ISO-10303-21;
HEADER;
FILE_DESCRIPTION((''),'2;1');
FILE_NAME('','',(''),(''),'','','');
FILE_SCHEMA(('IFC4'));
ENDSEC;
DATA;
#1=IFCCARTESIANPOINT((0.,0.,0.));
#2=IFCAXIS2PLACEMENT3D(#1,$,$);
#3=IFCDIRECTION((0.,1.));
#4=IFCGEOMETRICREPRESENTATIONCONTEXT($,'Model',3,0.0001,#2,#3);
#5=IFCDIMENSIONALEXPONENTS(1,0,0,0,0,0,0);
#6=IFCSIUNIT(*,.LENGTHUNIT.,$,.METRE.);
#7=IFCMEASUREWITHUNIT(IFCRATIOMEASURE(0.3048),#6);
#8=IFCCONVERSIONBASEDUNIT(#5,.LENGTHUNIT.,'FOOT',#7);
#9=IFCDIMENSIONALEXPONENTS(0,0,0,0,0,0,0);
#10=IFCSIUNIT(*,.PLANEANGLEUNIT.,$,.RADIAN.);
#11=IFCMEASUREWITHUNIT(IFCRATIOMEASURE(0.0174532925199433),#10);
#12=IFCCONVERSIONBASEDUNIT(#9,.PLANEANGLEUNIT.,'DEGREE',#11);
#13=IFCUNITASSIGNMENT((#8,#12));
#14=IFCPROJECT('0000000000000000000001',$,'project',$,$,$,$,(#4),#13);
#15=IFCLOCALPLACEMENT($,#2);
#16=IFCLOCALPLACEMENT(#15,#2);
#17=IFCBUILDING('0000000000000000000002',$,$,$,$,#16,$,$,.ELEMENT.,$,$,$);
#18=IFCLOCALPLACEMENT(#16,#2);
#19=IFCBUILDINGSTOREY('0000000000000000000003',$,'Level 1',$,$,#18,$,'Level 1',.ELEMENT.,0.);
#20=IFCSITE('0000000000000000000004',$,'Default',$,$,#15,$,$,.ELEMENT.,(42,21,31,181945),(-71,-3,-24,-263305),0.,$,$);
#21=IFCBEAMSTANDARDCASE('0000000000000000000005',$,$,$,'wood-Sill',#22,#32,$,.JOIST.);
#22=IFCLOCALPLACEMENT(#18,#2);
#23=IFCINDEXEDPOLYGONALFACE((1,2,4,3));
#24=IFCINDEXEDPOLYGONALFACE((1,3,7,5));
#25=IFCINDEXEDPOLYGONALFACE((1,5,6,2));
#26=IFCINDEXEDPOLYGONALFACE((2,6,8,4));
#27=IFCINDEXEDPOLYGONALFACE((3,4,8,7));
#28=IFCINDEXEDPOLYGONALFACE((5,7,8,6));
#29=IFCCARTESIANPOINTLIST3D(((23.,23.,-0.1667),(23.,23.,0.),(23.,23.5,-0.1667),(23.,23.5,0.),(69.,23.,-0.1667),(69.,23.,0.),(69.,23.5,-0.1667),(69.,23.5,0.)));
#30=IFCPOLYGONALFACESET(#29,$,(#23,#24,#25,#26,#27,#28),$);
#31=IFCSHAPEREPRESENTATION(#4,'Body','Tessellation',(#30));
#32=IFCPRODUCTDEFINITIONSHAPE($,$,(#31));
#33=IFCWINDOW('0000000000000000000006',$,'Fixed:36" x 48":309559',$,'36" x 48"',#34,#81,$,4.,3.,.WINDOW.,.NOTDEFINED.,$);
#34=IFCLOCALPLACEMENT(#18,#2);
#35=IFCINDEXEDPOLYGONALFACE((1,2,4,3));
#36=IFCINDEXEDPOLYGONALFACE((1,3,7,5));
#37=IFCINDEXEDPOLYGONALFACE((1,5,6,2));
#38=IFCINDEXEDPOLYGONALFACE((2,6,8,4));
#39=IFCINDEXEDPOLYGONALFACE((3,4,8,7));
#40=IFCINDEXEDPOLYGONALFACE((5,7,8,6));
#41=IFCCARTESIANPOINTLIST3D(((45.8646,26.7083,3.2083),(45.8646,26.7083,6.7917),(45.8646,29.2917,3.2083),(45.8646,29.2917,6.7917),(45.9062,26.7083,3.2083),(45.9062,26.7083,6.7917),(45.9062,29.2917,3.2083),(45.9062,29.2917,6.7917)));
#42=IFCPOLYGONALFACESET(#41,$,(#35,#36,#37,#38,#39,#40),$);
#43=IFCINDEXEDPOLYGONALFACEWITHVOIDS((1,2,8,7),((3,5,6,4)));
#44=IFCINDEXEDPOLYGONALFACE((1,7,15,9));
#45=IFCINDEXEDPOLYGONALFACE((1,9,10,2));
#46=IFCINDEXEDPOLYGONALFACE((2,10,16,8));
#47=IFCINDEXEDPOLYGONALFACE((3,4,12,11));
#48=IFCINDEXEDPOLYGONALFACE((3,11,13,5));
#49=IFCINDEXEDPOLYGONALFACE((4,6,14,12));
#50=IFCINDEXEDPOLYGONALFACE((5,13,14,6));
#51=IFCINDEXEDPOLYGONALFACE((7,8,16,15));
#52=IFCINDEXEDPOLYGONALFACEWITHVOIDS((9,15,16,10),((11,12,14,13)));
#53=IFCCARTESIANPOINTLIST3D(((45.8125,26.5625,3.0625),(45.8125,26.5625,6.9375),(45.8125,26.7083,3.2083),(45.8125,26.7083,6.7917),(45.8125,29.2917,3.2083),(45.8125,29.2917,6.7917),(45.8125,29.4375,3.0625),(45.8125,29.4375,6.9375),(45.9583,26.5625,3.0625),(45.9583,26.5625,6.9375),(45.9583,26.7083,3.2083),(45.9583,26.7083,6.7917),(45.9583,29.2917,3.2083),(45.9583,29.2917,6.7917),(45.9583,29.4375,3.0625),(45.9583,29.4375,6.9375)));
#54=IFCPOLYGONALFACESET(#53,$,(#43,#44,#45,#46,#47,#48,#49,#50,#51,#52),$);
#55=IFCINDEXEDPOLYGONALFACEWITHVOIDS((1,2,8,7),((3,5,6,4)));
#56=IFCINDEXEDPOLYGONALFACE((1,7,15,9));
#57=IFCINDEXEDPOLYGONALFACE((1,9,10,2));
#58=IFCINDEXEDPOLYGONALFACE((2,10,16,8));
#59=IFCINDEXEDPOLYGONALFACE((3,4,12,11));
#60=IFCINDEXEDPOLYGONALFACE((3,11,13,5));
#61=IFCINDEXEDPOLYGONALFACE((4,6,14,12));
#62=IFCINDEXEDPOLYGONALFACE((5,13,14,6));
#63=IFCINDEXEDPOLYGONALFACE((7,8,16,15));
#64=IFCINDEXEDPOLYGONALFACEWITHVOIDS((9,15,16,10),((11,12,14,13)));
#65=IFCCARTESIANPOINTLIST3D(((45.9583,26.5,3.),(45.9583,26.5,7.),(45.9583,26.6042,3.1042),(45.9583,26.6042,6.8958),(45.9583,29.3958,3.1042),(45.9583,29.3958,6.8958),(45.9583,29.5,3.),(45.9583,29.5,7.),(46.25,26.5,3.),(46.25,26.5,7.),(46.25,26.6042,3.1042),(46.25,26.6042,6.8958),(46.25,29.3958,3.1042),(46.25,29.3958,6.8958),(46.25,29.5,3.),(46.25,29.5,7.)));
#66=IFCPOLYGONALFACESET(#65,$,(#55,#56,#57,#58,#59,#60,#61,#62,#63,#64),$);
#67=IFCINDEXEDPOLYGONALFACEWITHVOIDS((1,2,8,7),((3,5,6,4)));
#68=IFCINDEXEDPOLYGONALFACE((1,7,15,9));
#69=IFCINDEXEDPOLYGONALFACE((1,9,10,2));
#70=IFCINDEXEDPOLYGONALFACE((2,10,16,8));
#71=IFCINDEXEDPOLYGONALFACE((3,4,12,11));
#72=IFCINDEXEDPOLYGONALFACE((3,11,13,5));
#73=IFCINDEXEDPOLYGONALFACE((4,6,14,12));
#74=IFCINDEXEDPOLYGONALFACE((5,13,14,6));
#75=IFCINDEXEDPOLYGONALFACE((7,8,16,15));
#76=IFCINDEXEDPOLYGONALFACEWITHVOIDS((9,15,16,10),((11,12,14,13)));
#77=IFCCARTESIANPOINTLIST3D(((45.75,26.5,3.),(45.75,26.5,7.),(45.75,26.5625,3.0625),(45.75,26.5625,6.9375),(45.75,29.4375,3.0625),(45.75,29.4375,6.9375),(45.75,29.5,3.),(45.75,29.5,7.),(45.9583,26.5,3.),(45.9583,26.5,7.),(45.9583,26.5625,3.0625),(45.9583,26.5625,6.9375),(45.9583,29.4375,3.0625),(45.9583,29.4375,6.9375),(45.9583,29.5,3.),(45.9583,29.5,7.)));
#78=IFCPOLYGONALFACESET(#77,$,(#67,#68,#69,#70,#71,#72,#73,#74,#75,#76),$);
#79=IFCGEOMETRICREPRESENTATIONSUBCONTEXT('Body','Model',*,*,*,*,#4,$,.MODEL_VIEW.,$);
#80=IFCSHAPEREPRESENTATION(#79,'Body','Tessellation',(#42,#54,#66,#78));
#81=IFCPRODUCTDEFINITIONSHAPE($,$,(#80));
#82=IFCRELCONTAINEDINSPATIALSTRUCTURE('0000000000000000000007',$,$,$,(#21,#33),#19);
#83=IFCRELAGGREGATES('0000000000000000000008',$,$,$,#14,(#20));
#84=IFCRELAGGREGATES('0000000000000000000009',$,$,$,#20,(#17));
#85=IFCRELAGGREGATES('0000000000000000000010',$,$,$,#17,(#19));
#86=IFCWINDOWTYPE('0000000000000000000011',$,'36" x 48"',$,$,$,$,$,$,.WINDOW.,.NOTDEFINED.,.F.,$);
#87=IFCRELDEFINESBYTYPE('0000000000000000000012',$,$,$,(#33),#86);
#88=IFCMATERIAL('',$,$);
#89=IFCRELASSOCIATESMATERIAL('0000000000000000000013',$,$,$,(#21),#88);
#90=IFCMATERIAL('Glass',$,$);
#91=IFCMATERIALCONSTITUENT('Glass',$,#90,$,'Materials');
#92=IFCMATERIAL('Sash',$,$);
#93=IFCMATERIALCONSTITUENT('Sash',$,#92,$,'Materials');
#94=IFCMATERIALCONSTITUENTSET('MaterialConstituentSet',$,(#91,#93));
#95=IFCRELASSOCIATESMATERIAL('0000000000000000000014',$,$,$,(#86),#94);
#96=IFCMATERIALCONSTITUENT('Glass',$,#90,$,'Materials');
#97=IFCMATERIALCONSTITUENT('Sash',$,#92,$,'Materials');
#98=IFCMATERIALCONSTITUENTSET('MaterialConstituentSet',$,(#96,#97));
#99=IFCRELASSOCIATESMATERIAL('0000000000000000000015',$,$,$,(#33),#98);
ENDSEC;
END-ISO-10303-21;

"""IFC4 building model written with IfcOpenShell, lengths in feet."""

from ifc_helpers import new_model, entity, si_unit, converted_unit, direction, frame, frame_2d, origin, place, context, subcontext, project, spatial, polyline, rectangle, outline, extrude, source, transform, mapped, material, constituent, constituent_set, type_object, type_shapes, element, save


model = new_model("IFC4")

# Units and contexts
model_context = context("Model", 3, precision=0.0001, world=origin(), true_north=direction((0.0, 1.0)))
body_context = subcontext(model_context, "Body", "Model", "MODEL_VIEW")
ifc_project = project(units=[converted_unit("LENGTHUNIT", "FOOT", entity("IfcRatioMeasure", 0.3048), si_unit("LENGTHUNIT", "METRE"), dimensions=[1, 0, 0, 0, 0, 0, 0]), converted_unit("PLANEANGLEUNIT", "DEGREE", entity("IfcRatioMeasure", 0.0174532925199433), si_unit("PLANEANGLEUNIT", "RADIAN"), dimensions=[0, 0, 0, 0, 0, 0, 0])], contexts=[model_context])

# Site, building, storey
site_placement = place(None, origin())
site = spatial("IfcSite", under=ifc_project, at=site_placement, Name="Default", CompositionType="ELEMENT", RefLatitude=(42, 21, 31, 181945), RefLongitude=(-71, -3, -24, -263305), RefElevation=0.0)
building_placement = place(site_placement, origin())
building = spatial("IfcBuilding", under=site, at=building_placement, CompositionType="ELEMENT")
storey_placement = place(building_placement, origin())
storey = spatial("IfcBuildingStorey", under=building, at=storey_placement, Name="Level 1", LongName="Level 1", CompositionType="ELEMENT", Elevation=0.0)

# Shared definitions
placement_1 = place(storey_placement, frame((46.0, 46.25, 0.0), z_axis=(0.0, 0.0, 1.0), x_axis=(0.0, -1.0, 0.0)))

# Beam
ifc_material_1 = material(Name="")
beam_1_placement = place(placement_1, frame((23.0, 0.0, -0.1667), z_axis=(0.0, 0.0, 1.0), x_axis=(0.0, -1.0, 0.0)))
element("IfcBeamStandardCase", 1, at=beam_1_placement, inside=storey, material=ifc_material_1, ObjectType="wood-Sill", PredefinedType="JOIST", context=model_context, shape_type="SweptSolid", body=[
    extrude(rectangle(XDim=46.0, YDim=0.5), origin(), (0.0, 0.0, 1.0), 0.1667),
])

# Window
ifc_material_2 = material(Name="Glass")
ifc_constituent_1 = constituent(ifc_material_2, Name="Glass", Category="Materials")
ifc_material_3 = material(Name="Sash")
ifc_constituent_2 = constituent(ifc_material_3, Name="Sash", Category="Materials")
ifc_constituent_set_1 = constituent_set(constituents=[ifc_constituent_1, ifc_constituent_2], Name="MaterialConstituentSet")
ifc_constituent_3 = constituent(ifc_material_2, Name="Glass", Category="Materials")
ifc_constituent_4 = constituent(ifc_material_3, Name="Sash", Category="Materials")
ifc_constituent_set_2 = constituent_set(constituents=[ifc_constituent_3, ifc_constituent_4], Name="MaterialConstituentSet")
window_type = type_object("IfcWindowType", Name="36\" x 48\"", ParameterTakesPrecedence=False, PartitioningType="NOTDEFINED", PredefinedType="WINDOW", material=ifc_constituent_set_2)
shared_shape = source(origin(), body_context, "Body", "SweptSolid", [
    extrude(rectangle(XDim=0.0417, YDim=2.5833, at=frame_2d((0.0, 0.0), x_axis=(1.0, 0.0))), frame((1.5, 0.3646, 0.2083), z_axis=(0.0, 0.0, 1.0), x_axis=(0.0, 1.0, 0.0)), (0.0, 0.0, 1.0), 3.5833),
    extrude(outline(polyline([(-1.4375, -1.9375), (1.4375, -1.9375), (1.4375, 1.9375), (-1.4375, 1.9375), (-1.4375, -1.9375)]), holes=[polyline([(-1.2917, -1.7917), (-1.2917, 1.7917), (1.2917, 1.7917), (1.2917, -1.7917), (-1.2917, -1.7917)])]), frame((1.5, 0.2917, 2.0), z_axis=(0.0, 1.0, 0.0), x_axis=(1.0, 0.0, 0.0)), (0.0, 0.0, 1.0), 0.1458),
    extrude(outline(polyline([(-1.5, -2.0), (1.5, -2.0), (1.5, 2.0), (-1.5, 2.0), (-1.5, -2.0)]), holes=[polyline([(-1.3958, -1.8958), (-1.3958, 1.8958), (1.3958, 1.8958), (1.3958, -1.8958), (-1.3958, -1.8958)])]), frame((1.5, 0.0, 2.0), z_axis=(0.0, 1.0, 0.0), x_axis=(1.0, 0.0, 0.0)), (0.0, 0.0, 1.0), 0.2917),
    extrude(outline(polyline([(-2.0, -1.5), (2.0, -1.5), (2.0, 1.5), (-2.0, 1.5), (-2.0, -1.5)]), holes=[polyline([(-1.9375, -1.4375), (-1.9375, 1.4375), (1.9375, 1.4375), (1.9375, -1.4375), (-1.9375, -1.4375)])]), frame((1.5, 0.2917, 2.0), z_axis=(0.0, 1.0, 0.0), x_axis=(0.0, 0.0, -1.0)), (0.0, 0.0, 1.0), 0.2083),
])
type_shapes(window_type, [shared_shape])
placement_2 = place(placement_1, frame((19.75, 0.25, 3.0)))
window_placement = place(placement_2, frame((0.0, 0.0, 0.0), z_axis=(0.0, 0.0, 1.0), x_axis=(-1.0, 0.0, 0.0)))
element("IfcWindow", 2, at=window_placement, inside=storey, type_object=window_type, material=ifc_constituent_set_1, Name="Fixed:36\" x 48\":309559", ObjectType="36\" x 48\"", OverallHeight=4.0, OverallWidth=3.0, PartitioningType="NOTDEFINED", PredefinedType="WINDOW", context=body_context, shape_type="MappedRepresentation", body=[
    mapped(shared_shape, transform((0.0, 0.0, 0.0), scale=1.0)),
])

save(model, "model.ifc")
